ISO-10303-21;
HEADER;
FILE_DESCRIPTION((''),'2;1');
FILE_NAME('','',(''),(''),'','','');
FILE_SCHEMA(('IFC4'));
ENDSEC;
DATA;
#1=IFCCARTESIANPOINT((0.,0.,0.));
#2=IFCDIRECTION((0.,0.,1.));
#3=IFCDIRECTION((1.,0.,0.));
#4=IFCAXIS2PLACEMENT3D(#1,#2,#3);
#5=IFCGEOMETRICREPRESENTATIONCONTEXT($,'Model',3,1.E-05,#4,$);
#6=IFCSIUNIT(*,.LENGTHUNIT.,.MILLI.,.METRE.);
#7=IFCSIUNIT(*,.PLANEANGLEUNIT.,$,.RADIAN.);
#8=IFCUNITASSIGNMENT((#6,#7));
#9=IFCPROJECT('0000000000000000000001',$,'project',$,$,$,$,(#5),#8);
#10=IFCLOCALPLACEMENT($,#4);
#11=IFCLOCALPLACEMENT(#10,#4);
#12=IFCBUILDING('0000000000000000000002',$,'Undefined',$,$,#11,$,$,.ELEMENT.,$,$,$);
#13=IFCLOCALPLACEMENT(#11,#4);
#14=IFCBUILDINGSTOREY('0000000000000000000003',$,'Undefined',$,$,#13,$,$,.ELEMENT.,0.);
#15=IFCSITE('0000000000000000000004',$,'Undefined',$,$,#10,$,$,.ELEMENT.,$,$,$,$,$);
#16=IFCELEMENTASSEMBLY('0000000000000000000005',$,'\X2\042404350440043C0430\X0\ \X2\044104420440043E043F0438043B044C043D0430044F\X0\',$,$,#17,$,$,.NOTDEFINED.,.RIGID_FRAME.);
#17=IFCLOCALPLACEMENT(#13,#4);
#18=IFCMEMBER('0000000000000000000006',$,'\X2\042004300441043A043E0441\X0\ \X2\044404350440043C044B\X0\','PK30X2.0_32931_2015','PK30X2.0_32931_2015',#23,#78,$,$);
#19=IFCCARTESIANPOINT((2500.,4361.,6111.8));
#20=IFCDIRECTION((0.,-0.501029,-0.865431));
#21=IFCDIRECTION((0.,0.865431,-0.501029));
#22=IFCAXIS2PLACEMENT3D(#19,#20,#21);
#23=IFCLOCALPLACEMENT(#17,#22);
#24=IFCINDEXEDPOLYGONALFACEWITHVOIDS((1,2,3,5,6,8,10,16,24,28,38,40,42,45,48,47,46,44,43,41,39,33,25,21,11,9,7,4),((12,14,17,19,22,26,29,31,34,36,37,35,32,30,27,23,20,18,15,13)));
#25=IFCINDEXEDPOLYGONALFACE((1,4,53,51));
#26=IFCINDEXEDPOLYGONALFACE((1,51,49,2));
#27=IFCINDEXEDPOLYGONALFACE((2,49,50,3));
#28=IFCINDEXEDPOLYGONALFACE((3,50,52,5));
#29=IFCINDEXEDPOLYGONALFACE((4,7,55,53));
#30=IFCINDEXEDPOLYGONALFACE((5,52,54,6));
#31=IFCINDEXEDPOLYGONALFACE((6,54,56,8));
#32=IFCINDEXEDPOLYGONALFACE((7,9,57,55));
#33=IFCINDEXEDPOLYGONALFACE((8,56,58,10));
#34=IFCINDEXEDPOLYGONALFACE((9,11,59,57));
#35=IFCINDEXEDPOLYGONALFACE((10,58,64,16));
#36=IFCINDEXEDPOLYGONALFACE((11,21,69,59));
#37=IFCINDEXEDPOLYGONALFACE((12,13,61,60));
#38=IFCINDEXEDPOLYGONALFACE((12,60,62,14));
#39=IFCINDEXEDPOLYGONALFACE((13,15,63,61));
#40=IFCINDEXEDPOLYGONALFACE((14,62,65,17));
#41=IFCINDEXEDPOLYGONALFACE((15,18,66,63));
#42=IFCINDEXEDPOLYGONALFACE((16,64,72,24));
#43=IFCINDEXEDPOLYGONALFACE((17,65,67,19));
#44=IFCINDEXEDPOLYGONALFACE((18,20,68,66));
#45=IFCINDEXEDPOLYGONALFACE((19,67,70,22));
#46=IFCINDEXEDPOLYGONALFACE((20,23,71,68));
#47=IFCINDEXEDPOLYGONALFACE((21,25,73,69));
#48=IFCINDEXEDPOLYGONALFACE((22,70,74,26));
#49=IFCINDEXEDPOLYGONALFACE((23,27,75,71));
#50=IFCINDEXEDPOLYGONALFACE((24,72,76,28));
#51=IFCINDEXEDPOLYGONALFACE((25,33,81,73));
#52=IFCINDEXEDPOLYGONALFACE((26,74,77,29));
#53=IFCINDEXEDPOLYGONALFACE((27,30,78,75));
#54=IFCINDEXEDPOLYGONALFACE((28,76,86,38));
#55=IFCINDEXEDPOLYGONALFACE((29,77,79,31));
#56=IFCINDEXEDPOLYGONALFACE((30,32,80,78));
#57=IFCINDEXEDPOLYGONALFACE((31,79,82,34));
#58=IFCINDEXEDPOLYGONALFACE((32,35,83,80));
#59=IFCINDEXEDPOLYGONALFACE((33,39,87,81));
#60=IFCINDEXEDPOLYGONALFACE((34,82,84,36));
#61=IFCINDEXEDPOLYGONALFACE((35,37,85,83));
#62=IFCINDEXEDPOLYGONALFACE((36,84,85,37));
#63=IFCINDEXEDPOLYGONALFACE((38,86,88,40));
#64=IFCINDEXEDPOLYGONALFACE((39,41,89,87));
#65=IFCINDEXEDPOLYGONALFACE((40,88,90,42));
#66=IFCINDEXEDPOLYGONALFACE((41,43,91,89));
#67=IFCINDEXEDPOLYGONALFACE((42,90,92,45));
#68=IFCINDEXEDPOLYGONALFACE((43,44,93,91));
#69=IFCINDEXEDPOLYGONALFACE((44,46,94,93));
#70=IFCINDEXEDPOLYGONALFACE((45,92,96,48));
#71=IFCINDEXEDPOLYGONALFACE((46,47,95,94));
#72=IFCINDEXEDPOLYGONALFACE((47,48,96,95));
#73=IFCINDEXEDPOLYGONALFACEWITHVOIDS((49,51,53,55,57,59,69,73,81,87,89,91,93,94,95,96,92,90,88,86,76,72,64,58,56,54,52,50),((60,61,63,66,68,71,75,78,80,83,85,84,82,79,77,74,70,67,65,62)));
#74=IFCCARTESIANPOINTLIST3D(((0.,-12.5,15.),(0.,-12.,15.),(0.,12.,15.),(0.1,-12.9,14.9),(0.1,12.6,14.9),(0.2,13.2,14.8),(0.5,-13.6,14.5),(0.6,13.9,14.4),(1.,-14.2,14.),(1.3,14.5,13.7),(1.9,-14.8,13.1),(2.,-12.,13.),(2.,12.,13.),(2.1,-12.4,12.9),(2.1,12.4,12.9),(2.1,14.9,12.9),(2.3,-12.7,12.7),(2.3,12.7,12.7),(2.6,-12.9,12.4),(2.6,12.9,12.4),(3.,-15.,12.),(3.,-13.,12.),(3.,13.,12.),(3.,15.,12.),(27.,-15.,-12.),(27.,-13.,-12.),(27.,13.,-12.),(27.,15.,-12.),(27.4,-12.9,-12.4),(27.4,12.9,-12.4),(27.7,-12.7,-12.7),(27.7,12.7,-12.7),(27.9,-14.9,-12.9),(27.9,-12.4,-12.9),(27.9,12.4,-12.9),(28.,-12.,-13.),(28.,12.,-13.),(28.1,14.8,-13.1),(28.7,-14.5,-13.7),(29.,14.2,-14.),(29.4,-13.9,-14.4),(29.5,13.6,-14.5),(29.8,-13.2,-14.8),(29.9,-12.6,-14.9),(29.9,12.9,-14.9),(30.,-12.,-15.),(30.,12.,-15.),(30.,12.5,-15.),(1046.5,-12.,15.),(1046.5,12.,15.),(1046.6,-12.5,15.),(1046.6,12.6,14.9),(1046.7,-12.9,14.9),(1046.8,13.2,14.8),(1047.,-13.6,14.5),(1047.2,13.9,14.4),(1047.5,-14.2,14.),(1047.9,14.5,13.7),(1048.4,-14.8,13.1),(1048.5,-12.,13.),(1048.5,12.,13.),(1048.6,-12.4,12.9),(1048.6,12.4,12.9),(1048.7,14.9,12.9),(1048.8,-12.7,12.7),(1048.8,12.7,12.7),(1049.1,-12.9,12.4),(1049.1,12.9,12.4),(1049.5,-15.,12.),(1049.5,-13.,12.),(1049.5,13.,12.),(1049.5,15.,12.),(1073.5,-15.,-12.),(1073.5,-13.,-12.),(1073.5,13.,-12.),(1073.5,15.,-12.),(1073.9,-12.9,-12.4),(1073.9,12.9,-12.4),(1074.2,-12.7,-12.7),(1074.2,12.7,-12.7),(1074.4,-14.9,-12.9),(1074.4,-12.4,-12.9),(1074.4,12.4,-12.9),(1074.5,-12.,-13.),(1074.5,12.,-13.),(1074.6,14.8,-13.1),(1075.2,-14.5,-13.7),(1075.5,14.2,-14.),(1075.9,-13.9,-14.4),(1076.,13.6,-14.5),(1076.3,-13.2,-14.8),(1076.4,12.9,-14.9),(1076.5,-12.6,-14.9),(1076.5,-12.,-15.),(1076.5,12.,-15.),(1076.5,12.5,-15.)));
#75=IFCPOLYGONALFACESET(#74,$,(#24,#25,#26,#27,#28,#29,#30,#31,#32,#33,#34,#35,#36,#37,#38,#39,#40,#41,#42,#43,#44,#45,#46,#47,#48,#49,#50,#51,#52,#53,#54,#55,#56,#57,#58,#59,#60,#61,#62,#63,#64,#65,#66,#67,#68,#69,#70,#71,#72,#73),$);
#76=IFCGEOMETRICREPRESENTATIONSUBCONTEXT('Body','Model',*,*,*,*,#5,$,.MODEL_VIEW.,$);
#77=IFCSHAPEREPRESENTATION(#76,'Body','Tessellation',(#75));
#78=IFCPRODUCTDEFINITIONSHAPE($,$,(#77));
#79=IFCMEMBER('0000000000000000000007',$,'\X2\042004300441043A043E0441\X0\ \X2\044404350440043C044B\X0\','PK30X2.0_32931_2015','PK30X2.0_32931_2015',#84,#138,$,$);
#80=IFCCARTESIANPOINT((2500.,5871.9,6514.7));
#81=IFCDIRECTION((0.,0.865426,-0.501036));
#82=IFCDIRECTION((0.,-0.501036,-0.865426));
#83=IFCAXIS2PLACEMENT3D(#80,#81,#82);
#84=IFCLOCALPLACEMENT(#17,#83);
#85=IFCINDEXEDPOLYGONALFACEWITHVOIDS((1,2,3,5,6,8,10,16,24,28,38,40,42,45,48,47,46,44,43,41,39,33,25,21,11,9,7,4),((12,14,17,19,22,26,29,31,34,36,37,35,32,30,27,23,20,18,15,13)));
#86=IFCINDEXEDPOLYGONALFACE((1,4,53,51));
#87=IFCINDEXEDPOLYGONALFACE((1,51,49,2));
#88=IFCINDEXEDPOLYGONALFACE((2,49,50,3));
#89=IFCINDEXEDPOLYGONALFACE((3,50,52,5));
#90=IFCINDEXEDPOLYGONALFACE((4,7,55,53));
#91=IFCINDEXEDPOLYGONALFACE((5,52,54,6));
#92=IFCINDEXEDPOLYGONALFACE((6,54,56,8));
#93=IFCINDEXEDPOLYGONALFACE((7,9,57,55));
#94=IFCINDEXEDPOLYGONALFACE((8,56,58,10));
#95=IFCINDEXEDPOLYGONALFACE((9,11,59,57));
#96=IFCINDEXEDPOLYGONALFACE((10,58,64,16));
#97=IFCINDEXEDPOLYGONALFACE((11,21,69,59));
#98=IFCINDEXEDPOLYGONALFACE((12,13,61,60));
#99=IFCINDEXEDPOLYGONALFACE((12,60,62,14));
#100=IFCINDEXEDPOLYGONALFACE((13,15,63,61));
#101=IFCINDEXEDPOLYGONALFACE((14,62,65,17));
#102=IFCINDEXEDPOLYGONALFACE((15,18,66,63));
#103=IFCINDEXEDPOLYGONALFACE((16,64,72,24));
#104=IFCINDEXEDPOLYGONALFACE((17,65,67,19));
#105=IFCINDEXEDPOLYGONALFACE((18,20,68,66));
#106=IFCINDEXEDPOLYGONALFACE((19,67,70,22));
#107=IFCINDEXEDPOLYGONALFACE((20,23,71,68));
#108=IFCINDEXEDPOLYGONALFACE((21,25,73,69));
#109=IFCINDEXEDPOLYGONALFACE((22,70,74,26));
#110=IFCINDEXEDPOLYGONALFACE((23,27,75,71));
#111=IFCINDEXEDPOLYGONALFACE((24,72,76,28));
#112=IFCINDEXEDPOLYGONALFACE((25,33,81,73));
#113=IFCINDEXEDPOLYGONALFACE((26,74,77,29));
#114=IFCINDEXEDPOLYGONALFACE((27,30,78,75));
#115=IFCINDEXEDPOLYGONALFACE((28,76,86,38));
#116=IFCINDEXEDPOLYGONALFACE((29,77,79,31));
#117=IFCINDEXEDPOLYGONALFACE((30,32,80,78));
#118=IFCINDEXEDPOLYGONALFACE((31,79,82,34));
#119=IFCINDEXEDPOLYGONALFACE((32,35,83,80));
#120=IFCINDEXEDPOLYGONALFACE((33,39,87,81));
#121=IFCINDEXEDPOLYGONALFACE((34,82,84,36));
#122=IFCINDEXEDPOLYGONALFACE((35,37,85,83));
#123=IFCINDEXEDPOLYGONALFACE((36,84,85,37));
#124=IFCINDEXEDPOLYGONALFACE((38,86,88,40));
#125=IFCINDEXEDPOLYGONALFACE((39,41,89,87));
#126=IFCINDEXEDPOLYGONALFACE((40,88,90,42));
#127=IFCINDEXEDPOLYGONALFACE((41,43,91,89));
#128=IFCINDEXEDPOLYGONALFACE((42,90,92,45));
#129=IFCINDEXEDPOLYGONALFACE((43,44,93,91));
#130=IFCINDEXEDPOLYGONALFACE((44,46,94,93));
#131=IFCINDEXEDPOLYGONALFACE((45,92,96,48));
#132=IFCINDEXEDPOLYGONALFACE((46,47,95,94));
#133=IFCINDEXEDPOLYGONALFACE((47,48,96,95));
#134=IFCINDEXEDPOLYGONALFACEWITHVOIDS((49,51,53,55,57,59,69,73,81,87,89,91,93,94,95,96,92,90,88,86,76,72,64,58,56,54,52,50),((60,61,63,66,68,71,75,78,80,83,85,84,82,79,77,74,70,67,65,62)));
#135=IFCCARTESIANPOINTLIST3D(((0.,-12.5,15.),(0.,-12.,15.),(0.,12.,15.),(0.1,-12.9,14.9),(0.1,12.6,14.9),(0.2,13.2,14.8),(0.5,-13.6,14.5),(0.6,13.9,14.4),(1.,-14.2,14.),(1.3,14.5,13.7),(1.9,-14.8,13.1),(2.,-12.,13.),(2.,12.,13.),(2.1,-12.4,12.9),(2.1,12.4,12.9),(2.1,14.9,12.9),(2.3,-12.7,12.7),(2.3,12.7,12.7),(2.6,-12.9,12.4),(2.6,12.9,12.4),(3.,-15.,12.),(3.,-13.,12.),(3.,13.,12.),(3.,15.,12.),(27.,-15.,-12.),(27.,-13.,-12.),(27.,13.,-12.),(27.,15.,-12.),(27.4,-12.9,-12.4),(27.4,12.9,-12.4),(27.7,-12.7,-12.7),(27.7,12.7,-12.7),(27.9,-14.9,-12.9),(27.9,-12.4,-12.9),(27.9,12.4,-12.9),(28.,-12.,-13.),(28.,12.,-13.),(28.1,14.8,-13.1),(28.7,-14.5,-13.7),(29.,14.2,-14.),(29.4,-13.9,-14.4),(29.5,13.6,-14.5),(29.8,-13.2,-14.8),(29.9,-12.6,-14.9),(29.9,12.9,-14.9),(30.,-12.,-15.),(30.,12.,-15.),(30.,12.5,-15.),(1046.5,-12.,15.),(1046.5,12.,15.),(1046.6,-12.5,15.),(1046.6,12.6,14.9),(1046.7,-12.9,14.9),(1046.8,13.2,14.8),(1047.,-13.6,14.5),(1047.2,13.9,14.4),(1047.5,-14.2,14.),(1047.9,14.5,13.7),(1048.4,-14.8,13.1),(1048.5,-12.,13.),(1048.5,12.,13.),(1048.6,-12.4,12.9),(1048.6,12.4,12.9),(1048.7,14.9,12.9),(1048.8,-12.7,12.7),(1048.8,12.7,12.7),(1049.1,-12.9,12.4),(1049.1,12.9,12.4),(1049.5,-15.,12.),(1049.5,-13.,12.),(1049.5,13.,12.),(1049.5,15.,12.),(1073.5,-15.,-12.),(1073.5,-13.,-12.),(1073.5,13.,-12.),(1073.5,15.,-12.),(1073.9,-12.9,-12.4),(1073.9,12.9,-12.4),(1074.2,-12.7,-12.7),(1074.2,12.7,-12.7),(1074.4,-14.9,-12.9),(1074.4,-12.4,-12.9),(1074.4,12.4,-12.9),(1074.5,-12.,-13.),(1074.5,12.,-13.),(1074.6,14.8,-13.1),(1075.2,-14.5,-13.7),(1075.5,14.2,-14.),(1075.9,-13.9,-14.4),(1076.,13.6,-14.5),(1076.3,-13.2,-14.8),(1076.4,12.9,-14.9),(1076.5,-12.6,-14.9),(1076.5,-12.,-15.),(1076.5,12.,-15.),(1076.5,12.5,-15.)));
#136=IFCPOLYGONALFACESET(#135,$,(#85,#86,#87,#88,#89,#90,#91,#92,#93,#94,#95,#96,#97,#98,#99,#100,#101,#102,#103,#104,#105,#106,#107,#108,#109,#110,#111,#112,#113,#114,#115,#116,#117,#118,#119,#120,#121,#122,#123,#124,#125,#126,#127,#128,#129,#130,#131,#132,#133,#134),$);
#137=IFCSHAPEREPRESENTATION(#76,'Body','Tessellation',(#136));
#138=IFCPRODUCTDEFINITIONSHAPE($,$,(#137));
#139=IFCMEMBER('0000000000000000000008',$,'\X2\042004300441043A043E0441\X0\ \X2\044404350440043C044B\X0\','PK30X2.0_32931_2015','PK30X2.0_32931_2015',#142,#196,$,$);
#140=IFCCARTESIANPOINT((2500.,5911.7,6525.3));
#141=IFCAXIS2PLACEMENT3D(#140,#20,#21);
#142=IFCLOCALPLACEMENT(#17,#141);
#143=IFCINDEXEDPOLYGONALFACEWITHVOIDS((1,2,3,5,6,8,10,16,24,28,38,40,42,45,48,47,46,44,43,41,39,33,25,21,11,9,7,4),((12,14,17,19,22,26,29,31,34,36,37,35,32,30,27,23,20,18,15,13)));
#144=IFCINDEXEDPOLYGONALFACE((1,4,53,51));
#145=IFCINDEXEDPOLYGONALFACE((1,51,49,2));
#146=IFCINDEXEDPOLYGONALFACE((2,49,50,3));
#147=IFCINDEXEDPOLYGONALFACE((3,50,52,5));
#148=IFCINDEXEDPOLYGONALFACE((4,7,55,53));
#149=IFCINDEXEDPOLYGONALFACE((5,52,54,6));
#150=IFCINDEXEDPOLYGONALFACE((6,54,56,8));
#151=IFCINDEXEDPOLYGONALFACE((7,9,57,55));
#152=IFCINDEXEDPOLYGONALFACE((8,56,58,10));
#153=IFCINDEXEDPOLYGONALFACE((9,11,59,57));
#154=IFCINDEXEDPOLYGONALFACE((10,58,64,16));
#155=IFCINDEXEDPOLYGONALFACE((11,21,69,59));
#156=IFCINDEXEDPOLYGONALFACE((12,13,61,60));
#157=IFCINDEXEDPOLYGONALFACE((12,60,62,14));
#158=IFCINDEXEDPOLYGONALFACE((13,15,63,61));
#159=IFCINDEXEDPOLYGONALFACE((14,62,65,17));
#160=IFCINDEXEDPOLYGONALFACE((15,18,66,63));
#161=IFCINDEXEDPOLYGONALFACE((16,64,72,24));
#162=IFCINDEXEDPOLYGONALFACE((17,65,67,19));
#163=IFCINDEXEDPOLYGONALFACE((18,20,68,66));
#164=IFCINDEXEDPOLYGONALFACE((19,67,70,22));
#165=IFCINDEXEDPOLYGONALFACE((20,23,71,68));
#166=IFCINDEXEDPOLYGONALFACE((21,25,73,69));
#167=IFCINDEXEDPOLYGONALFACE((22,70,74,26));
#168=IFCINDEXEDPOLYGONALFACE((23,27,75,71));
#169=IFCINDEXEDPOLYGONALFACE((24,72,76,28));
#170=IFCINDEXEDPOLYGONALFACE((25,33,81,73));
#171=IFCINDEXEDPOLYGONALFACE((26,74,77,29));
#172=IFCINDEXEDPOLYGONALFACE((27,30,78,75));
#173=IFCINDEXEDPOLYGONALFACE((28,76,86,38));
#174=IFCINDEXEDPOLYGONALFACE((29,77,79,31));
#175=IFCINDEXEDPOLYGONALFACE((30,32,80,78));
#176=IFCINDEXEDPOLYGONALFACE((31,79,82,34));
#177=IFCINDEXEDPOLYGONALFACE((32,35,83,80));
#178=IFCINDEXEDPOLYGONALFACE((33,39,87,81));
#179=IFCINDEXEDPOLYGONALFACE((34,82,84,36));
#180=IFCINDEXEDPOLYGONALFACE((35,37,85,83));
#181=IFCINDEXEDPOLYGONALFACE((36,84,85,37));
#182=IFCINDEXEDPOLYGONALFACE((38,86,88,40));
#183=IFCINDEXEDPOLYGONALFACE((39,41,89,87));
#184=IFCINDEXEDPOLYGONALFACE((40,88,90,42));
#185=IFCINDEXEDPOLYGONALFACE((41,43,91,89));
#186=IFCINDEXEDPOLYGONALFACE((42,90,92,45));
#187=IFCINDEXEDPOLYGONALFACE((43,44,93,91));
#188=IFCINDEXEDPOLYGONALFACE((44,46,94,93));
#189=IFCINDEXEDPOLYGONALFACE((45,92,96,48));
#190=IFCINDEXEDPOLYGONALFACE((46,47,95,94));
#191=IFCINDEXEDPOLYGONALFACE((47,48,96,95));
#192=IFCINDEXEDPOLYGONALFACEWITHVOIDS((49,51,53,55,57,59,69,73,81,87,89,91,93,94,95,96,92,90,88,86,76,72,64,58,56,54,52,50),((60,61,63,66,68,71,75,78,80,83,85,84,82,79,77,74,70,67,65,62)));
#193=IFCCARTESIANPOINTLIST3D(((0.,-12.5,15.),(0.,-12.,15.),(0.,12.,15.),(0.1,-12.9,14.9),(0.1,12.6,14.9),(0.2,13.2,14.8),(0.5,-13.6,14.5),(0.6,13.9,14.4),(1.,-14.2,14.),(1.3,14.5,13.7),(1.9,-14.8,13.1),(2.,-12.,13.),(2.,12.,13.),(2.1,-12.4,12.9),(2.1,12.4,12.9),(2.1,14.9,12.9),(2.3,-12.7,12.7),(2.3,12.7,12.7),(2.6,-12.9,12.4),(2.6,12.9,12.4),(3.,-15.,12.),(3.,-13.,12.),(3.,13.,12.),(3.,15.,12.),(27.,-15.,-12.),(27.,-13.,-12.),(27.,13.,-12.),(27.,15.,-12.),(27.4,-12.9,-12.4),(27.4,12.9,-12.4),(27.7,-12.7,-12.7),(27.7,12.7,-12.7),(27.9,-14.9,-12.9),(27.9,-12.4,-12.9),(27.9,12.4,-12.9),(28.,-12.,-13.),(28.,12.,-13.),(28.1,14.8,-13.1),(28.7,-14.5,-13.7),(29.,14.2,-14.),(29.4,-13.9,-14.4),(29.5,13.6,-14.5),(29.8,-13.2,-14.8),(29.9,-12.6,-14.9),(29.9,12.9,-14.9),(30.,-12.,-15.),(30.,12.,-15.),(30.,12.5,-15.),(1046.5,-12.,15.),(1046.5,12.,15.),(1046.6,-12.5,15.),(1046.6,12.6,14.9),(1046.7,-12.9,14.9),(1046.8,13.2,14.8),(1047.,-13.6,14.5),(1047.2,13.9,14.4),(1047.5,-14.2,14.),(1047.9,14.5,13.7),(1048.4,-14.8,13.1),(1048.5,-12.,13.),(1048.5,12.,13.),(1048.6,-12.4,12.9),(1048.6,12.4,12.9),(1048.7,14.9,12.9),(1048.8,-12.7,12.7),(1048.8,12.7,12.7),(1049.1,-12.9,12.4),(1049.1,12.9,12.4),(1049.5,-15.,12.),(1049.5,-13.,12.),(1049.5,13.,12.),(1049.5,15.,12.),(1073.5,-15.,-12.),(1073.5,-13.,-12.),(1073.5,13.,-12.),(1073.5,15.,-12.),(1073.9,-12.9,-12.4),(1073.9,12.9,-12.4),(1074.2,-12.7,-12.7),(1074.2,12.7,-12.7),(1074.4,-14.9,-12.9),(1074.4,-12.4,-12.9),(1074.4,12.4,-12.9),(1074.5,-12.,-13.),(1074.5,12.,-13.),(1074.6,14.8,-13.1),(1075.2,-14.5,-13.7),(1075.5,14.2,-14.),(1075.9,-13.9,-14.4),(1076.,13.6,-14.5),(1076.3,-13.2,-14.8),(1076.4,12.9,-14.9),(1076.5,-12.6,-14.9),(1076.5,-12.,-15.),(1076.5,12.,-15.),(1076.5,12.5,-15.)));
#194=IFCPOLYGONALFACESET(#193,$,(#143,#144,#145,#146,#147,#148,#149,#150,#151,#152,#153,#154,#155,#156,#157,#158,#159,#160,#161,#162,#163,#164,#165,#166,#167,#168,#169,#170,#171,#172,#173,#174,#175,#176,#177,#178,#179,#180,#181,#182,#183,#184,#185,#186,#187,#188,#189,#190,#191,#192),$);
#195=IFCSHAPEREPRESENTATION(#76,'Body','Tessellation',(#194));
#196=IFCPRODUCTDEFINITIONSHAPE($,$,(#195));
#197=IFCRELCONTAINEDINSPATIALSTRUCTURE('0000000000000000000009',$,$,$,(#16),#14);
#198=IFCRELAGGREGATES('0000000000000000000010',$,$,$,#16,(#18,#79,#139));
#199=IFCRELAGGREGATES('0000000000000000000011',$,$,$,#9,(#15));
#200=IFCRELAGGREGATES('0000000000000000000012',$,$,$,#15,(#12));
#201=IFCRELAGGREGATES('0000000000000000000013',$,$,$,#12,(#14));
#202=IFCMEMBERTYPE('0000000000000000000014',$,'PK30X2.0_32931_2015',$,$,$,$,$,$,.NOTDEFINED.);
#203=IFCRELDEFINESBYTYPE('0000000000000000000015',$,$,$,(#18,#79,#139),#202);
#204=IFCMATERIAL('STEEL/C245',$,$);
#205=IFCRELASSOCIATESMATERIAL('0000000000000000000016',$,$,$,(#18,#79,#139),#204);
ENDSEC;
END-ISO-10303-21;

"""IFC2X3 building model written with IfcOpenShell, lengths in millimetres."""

from ifc_helpers import new_model, si_unit, frame, origin_with_axes, origin_2d_with_axis, place, context, subcontext, project, spatial, hollow_rectangle, extrude, clip, halfspace, material, type_object, element, aggregate, save


model = new_model("IFC2X3")

# Units and contexts
model_context = context("Model", 3, precision=1e-05, world=origin_with_axes())
body_context = subcontext(model_context, "Body", "Model", "MODEL_VIEW")
ifc_project = project(units=[si_unit("LENGTHUNIT", "METRE", prefix="MILLI"), si_unit("PLANEANGLEUNIT", "RADIAN")], contexts=[model_context])

# Site, building, storey
site_placement = place(None, origin_with_axes())
site = spatial("IfcSite", under=ifc_project, at=site_placement, Name="Undefined", CompositionType="ELEMENT")
building_placement = place(site_placement, origin_with_axes())
building = spatial("IfcBuilding", under=site, at=building_placement, Name="Undefined", CompositionType="ELEMENT")
storey_placement = place(building_placement, origin_with_axes())
storey = spatial("IfcBuildingStorey", under=building, at=storey_placement, Name="Undefined", CompositionType="ELEMENT", Elevation=0.0)

# Element assembly
ifc_material_1 = material(Name="STEEL/C245")
assembly_1_placement = place(storey_placement, origin_with_axes())
assembly_1 = element("IfcElementAssembly", 1, at=assembly_1_placement, inside=storey, Name="Ферма стропильная", AssemblyPlace="NOTDEFINED", PredefinedType="RIGID_FRAME")

# Members
member_type = type_object("IfcMemberType", Name="PK30X2.0_32931_2015", PredefinedType="NOTDEFINED")
member_1_placement = place(assembly_1_placement, frame((2500.0, 4361.0, 6111.8), z_axis=(0.0, -0.501029, -0.865431), x_axis=(0.0, 0.865431, -0.501029)))
member_1 = element("IfcMember", 2, at=member_1_placement, type_object=member_type, material=ifc_material_1, Name="Раскос фермы", Description="PK30X2.0_32931_2015", ObjectType="PK30X2.0_32931_2015", context=body_context, shape_type="Clipping", body=[
    clip(clip(extrude(hollow_rectangle(XDim=30.0, YDim=30.0, WallThickness=2.0, InnerFilletRadius=1.0, OuterFilletRadius=3.0, at=origin_2d_with_axis()), frame((1102.9, 0.0, 0.0), z_axis=(-1.0, 0.0, 0.0), x_axis=(0.0, -1.0, 0.0)), (0.0, 0.0, 1.0), 1129.2), halfspace(frame((1060.0, 0.0, 1.5), z_axis=(-0.707107, 0.0, -0.707107), x_axis=(0.0, -1.0, 0.0)), True)), halfspace(frame((34.5, 0.0, -19.5), z_axis=(-0.707107, 0.0, -0.707107), x_axis=(0.0, -1.0, 0.0)), False)),
])
member_2_placement = place(assembly_1_placement, frame((2500.0, 5871.9, 6514.7), z_axis=(0.0, 0.865426, -0.501036), x_axis=(0.0, -0.501036, -0.865426)))
member_2 = element("IfcMember", 3, at=member_2_placement, type_object=member_type, material=ifc_material_1, Name="Раскос фермы", Description="PK30X2.0_32931_2015", ObjectType="PK30X2.0_32931_2015", context=body_context, shape_type="Clipping", body=[
    clip(clip(extrude(hollow_rectangle(XDim=30.0, YDim=30.0, WallThickness=2.0, InnerFilletRadius=1.0, OuterFilletRadius=3.0, at=origin_2d_with_axis()), frame((1091.8, 0.0, 0.0), z_axis=(-1.0, 0.0, 0.0), x_axis=(0.0, -1.0, 0.0)), (0.0, 0.0, 1.0), 1107.1), halfspace(frame((1060.0, 0.0, 1.5), z_axis=(-0.707107, 0.0, -0.707107), x_axis=(0.0, -1.0, 0.0)), True)), halfspace(frame((34.5, 0.0, -19.5), z_axis=(-0.707107, 0.0, -0.707107), x_axis=(0.0, -1.0, 0.0)), False)),
])
member_3_placement = place(assembly_1_placement, frame((2500.0, 5911.7, 6525.3), z_axis=(0.0, -0.501029, -0.865431), x_axis=(0.0, 0.865431, -0.501029)))
member_3 = element("IfcMember", 4, at=member_3_placement, type_object=member_type, material=ifc_material_1, Name="Раскос фермы", Description="PK30X2.0_32931_2015", ObjectType="PK30X2.0_32931_2015", context=body_context, shape_type="Clipping", body=[
    clip(clip(extrude(hollow_rectangle(XDim=30.0, YDim=30.0, WallThickness=2.0, InnerFilletRadius=1.0, OuterFilletRadius=3.0, at=origin_2d_with_axis()), frame((1102.9, 0.0, 0.0), z_axis=(-1.0, 0.0, 0.0), x_axis=(0.0, -1.0, 0.0)), (0.0, 0.0, 1.0), 1129.2), halfspace(frame((1060.0, 0.0, 1.5), z_axis=(-0.707107, 0.0, -0.707107), x_axis=(0.0, -1.0, 0.0)), True)), halfspace(frame((34.5, 0.0, -19.5), z_axis=(-0.707107, 0.0, -0.707107), x_axis=(0.0, -1.0, 0.0)), False)),
])
aggregate(assembly_1, [member_1, member_2, member_3])

save(model, "model.ifc")
